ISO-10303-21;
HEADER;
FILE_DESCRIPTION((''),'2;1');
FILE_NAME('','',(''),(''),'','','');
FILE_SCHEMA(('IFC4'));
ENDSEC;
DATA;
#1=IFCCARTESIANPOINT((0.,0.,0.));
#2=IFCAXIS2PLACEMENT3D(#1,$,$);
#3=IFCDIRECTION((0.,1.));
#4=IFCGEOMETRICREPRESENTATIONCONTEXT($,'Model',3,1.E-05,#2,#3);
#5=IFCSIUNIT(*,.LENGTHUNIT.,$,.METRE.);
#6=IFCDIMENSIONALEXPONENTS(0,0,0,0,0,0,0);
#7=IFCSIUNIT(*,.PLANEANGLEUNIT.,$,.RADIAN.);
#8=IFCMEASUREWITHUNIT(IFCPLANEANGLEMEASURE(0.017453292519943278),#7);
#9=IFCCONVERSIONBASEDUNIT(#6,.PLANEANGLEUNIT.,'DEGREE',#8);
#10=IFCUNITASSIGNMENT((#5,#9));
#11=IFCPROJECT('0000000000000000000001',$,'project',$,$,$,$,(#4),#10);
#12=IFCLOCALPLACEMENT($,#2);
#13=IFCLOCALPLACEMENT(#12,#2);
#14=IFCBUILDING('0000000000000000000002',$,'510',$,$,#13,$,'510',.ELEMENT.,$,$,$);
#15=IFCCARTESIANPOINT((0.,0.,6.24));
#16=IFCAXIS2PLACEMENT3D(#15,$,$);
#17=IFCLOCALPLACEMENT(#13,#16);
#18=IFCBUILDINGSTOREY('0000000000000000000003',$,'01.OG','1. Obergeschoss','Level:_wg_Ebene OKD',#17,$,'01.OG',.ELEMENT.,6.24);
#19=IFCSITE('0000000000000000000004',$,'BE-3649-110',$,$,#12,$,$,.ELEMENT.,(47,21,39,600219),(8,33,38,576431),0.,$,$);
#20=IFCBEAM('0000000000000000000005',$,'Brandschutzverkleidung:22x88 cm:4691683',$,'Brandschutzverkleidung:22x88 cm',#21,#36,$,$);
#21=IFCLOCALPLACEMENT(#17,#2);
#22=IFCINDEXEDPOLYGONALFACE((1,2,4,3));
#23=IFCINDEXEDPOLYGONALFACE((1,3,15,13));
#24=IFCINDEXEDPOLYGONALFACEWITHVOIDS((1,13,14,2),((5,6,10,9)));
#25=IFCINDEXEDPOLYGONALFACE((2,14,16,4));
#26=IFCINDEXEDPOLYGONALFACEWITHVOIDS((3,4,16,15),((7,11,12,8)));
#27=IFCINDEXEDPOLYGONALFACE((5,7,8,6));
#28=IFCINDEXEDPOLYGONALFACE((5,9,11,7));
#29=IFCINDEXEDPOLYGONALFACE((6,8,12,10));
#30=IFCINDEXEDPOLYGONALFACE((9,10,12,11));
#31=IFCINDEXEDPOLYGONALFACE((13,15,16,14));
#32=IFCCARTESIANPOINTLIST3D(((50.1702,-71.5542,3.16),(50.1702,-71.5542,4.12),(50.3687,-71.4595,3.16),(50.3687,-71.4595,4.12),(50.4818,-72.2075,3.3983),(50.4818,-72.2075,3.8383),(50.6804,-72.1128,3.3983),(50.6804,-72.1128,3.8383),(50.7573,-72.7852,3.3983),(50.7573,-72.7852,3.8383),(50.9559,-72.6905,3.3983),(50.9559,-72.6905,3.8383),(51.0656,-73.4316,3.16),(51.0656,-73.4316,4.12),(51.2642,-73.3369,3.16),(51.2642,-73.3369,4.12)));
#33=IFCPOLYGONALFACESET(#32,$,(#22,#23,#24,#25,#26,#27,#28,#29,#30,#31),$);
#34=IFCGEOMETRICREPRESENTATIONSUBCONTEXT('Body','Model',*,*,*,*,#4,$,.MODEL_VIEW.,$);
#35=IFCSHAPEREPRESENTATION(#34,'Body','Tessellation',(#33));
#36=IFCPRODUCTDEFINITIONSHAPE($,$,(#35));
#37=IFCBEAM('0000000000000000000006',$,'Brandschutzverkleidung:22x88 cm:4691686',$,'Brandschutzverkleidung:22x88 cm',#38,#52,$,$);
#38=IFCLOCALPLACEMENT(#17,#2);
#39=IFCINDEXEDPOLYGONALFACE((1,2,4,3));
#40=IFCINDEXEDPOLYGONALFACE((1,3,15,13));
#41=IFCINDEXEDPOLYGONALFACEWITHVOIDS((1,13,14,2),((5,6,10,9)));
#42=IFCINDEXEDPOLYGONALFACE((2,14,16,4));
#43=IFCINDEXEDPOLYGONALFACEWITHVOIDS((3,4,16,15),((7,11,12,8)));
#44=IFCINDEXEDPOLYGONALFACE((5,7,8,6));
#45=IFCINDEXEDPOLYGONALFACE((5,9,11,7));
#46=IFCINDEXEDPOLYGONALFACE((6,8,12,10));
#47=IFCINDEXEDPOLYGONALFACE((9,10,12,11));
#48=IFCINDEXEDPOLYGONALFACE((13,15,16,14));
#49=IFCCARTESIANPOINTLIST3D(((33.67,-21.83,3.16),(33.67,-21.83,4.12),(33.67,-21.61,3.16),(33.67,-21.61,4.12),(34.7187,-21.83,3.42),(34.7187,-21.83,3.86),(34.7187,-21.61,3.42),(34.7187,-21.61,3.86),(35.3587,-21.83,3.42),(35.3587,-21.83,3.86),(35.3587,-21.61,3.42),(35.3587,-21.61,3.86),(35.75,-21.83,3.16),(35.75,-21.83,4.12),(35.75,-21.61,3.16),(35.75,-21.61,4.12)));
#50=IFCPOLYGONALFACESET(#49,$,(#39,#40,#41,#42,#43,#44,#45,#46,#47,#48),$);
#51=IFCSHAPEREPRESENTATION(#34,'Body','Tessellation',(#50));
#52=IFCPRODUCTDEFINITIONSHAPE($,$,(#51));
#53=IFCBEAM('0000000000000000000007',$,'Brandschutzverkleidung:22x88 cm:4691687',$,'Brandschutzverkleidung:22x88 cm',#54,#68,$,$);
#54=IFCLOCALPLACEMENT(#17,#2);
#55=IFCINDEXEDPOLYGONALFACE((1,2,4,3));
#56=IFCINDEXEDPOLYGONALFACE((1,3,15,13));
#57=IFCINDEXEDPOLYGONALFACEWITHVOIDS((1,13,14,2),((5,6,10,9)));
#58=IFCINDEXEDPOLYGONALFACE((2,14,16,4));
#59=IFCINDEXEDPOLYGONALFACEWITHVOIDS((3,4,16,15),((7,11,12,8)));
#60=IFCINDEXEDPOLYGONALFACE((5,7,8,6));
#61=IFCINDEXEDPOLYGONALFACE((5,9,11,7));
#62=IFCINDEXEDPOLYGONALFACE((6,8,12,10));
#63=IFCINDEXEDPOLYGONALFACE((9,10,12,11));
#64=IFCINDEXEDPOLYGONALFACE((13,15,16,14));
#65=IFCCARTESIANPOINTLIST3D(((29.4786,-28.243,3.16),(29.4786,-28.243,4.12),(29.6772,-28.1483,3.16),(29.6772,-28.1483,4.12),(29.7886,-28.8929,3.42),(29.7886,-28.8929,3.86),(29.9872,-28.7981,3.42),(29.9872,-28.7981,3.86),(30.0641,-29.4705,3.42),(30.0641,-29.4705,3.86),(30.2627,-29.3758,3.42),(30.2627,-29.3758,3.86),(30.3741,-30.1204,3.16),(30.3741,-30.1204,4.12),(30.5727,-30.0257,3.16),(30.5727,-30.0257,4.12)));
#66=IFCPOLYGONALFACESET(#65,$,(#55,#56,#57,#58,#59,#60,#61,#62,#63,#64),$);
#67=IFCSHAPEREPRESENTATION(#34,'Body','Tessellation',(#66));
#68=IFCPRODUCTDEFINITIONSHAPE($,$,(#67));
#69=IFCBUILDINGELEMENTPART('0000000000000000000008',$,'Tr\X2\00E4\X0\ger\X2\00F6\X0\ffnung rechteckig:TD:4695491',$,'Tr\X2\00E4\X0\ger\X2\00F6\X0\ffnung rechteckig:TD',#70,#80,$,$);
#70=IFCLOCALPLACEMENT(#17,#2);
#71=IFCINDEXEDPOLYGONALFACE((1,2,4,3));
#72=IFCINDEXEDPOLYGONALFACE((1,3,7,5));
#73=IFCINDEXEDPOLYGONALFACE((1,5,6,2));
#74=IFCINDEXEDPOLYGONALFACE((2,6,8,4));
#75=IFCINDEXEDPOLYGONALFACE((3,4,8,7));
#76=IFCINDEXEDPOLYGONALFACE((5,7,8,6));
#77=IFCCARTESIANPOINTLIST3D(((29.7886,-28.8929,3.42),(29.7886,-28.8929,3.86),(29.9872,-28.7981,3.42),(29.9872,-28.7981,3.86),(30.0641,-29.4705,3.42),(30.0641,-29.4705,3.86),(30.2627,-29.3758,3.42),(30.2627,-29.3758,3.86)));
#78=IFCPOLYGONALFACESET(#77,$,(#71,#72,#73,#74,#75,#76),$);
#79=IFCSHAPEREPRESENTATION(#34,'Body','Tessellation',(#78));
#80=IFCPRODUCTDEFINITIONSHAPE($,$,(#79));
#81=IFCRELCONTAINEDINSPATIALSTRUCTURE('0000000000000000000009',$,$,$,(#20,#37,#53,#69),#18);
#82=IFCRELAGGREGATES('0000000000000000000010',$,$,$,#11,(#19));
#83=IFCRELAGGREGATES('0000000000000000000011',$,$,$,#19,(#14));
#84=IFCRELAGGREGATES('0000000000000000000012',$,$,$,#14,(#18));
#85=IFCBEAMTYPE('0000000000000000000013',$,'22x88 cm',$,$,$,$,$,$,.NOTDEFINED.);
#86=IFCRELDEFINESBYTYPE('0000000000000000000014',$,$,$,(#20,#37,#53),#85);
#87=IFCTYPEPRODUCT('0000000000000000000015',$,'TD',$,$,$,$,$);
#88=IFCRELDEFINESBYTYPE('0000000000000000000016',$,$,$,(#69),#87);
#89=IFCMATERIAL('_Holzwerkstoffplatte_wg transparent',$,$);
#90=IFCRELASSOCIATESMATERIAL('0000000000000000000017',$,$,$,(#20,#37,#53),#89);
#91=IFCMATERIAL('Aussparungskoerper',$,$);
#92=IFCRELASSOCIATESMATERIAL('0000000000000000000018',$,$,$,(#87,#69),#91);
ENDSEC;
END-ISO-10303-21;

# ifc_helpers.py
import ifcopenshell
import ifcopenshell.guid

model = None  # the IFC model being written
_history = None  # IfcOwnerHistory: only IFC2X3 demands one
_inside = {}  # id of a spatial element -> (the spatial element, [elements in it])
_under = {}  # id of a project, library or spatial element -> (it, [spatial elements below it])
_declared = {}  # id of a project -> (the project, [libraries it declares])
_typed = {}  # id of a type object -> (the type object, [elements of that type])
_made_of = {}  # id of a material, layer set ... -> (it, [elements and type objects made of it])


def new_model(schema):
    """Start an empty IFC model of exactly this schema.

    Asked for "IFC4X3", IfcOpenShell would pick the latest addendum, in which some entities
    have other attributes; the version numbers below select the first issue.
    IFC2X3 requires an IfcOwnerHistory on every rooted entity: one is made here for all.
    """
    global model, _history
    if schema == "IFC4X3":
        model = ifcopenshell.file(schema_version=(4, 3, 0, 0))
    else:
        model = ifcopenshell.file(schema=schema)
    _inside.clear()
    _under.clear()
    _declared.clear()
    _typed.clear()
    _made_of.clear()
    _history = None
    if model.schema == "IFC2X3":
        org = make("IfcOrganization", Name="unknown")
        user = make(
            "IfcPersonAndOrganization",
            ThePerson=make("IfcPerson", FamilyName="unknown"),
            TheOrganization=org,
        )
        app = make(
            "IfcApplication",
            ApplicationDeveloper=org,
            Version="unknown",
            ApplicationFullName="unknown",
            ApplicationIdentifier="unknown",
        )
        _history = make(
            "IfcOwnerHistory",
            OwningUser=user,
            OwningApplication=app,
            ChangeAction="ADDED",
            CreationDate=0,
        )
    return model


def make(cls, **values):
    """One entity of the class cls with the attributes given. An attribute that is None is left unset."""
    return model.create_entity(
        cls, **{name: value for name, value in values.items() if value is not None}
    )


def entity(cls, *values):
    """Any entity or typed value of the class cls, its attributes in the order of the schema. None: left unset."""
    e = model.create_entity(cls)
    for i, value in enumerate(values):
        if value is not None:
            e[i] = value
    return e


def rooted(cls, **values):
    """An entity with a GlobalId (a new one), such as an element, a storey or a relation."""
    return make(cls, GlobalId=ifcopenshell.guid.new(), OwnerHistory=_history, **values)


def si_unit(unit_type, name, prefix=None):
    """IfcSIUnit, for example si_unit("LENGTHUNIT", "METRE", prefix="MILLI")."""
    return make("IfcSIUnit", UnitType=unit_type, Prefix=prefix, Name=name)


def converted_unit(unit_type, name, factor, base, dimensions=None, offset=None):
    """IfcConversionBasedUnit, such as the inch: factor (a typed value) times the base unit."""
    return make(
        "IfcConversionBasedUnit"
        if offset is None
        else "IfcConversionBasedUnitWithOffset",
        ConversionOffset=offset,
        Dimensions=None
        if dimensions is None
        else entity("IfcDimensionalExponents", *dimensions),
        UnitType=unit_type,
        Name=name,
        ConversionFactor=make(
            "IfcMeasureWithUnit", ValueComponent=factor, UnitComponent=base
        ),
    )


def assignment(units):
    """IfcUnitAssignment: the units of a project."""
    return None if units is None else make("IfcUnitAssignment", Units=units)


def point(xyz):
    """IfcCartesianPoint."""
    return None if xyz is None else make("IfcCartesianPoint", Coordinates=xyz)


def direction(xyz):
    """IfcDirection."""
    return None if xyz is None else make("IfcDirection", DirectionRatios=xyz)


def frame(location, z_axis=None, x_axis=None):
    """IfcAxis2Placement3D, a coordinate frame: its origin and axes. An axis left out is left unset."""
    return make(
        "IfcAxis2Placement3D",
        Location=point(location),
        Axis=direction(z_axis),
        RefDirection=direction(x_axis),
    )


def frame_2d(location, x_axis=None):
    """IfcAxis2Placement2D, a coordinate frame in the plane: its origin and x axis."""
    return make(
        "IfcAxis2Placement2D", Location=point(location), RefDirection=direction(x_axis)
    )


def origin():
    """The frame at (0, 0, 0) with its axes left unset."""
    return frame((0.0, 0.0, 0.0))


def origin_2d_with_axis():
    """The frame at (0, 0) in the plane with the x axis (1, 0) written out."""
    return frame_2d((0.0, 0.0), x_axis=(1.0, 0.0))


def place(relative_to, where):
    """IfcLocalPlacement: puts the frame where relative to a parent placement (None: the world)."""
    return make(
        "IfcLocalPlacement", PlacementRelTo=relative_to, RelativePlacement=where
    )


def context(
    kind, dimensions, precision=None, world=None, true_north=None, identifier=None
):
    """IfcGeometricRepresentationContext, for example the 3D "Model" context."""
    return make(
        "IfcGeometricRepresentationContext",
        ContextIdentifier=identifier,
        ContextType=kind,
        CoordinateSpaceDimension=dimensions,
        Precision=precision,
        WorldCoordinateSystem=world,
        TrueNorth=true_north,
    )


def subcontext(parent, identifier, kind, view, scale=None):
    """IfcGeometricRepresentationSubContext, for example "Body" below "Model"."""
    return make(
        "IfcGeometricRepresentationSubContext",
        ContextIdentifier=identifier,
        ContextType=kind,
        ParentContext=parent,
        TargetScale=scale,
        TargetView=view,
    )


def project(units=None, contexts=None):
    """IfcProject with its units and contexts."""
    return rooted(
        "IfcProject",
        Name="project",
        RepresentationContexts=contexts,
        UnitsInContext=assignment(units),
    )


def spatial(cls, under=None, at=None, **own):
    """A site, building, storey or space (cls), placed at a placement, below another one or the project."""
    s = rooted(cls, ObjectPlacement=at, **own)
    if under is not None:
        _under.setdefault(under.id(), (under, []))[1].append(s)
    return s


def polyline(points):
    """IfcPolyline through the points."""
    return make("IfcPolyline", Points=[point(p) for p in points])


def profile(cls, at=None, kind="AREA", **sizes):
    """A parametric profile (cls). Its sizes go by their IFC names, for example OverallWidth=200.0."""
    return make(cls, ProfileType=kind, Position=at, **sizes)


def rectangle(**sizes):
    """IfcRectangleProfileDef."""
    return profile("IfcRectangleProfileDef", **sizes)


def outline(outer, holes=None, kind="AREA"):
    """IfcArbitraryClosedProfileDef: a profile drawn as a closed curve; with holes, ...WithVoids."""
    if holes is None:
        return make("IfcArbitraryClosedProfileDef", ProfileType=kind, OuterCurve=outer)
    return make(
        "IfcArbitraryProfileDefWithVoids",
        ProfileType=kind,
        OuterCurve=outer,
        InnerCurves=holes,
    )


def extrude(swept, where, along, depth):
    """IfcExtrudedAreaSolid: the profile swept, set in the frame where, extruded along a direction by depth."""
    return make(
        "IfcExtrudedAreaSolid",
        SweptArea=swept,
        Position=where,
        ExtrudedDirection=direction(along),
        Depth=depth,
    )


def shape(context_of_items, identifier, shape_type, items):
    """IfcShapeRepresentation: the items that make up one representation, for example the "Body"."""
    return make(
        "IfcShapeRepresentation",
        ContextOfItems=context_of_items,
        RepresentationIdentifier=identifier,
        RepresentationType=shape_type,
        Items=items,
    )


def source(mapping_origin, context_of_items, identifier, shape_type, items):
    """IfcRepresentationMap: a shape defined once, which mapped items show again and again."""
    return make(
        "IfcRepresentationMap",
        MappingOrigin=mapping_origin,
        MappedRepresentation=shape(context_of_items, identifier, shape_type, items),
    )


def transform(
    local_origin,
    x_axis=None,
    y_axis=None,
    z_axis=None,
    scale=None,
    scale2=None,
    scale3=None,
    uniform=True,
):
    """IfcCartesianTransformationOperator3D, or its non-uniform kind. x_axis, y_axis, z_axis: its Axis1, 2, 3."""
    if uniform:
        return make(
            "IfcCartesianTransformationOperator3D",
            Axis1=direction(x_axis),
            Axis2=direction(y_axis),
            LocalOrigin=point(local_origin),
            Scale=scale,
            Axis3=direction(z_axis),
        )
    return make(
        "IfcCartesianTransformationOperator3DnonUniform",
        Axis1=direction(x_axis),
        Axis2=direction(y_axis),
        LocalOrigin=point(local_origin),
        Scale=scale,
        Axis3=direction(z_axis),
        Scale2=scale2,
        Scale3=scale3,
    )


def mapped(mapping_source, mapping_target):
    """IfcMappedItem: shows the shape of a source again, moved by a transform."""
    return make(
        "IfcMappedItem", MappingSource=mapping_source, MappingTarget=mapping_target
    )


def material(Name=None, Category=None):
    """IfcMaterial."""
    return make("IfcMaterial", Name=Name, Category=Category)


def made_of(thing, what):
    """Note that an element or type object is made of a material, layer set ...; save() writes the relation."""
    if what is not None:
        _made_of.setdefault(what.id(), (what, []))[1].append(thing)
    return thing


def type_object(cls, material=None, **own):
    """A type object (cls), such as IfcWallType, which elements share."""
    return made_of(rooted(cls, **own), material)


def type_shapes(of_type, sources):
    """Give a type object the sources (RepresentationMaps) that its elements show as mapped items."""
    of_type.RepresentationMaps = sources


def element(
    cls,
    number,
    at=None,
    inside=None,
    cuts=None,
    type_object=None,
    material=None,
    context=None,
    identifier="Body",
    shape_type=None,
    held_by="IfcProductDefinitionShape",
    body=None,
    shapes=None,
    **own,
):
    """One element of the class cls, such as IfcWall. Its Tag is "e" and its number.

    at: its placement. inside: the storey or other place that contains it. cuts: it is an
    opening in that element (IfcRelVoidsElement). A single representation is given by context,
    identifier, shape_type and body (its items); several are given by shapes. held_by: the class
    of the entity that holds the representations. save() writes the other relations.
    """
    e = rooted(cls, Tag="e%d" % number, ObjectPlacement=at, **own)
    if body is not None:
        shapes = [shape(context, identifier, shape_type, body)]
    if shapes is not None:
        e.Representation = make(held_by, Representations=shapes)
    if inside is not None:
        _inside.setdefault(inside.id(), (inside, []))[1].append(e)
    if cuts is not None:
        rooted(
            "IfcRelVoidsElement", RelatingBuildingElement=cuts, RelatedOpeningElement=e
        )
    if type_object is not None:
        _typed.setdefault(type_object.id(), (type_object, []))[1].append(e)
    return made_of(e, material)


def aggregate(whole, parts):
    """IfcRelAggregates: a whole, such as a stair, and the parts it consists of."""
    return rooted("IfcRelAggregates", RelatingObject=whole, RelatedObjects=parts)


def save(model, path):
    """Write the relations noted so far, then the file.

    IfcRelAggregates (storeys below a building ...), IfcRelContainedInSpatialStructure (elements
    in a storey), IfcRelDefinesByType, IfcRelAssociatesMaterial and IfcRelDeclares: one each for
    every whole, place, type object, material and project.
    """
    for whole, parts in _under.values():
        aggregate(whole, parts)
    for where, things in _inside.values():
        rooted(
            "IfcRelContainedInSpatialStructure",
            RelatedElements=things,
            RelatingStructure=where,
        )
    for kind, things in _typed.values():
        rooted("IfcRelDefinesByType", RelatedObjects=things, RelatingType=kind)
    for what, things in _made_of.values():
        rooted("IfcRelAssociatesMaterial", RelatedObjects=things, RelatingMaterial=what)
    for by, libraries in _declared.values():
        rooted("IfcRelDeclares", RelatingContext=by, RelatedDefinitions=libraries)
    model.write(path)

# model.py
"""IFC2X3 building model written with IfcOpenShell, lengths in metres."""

from ifc_helpers import new_model, entity, si_unit, converted_unit, direction, frame, origin, origin_2d_with_axis, place, context, subcontext, project, spatial, polyline, rectangle, outline, extrude, source, transform, mapped, material, type_object, type_shapes, element, save


model = new_model("IFC2X3")

# Units and contexts
model_context = context("Model", 3, precision=1e-05, world=origin(), true_north=direction((0.0, 1.0)))
body_context = subcontext(model_context, "Body", "Model", "MODEL_VIEW")
ifc_project = project(units=[si_unit("LENGTHUNIT", "METRE"), converted_unit("PLANEANGLEUNIT", "DEGREE", entity("IfcPlaneAngleMeasure", 0.017453292519943278), si_unit("PLANEANGLEUNIT", "RADIAN"), dimensions=[0, 0, 0, 0, 0, 0, 0])], contexts=[model_context])

# Site, building, storey
site_placement = place(None, origin())
site = spatial("IfcSite", under=ifc_project, at=site_placement, Name="BE-3649-110", CompositionType="ELEMENT", RefLatitude=(47, 21, 39, 600219), RefLongitude=(8, 33, 38, 576431), RefElevation=0.0)
building_placement = place(site_placement, origin())
building = spatial("IfcBuilding", under=site, at=building_placement, Name="510", LongName="510", CompositionType="ELEMENT")
storey_placement = place(building_placement, frame((0.0, 0.0, 6.24)))
storey = spatial("IfcBuildingStorey", under=building, at=storey_placement, Name="01.OG", Description="1. Obergeschoss", ObjectType="Level:_wg_Ebene OKD", LongName="01.OG", CompositionType="ELEMENT", Elevation=6.24)

# Beams
ifc_material_1 = material(Name="_Holzwerkstoffplatte_wg transparent")
beam_type_1 = type_object("IfcBeamType", Name="22x88 cm", PredefinedType="NOTDEFINED")
beam_1_placement = place(storey_placement, frame((0.0, 0.0, 3.64)))
element("IfcBeam", 1, at=beam_1_placement, inside=storey, type_object=beam_type_1, material=ifc_material_1, Name="Brandschutzverkleidung:22x88 cm:4691683", ObjectType="Brandschutzverkleidung:22x88 cm", context=body_context, shape_type="SweptSolid", body=[
    extrude(outline(polyline([(-1.04, -0.48), (1.04, -0.48), (1.04, 0.48), (-1.04, 0.48), (-1.04, -0.48)]), holes=[polyline([(0.3238, 0.2417), (0.3238, -0.1983), (-0.3162, -0.1983), (-0.3162, 0.2417), (0.3238, 0.2417)])]), frame((50.6179, -72.4929, 0.0), z_axis=(0.902585, 0.430511, 0.0), x_axis=(0.430511, -0.902585, 0.0)), (0.0, 0.0, 1.0), 0.22),
])
beam_2_placement = place(storey_placement, frame((0.0, 0.0, 3.64)))
element("IfcBeam", 2, at=beam_2_placement, inside=storey, type_object=beam_type_1, material=ifc_material_1, Name="Brandschutzverkleidung:22x88 cm:4691686", ObjectType="Brandschutzverkleidung:22x88 cm", context=body_context, shape_type="SweptSolid", body=[
    extrude(outline(polyline([(-1.04, -0.48), (1.04, -0.48), (1.04, 0.48), (-1.04, 0.48), (-1.04, -0.48)]), holes=[polyline([(0.6487, 0.22), (0.6487, -0.22), (0.0087, -0.22), (0.0087, 0.22), (0.6487, 0.22)])]), frame((34.71, -21.83, 0.0), z_axis=(0.0, 1.0, 0.0), x_axis=(1.0, 0.0, 0.0)), (0.0, 0.0, 1.0), 0.22),
])
beam_3_placement = place(storey_placement, frame((0.0, 0.0, 3.64)))
element("IfcBeam", 3, at=beam_3_placement, inside=storey, type_object=beam_type_1, material=ifc_material_1, Name="Brandschutzverkleidung:22x88 cm:4691687", ObjectType="Brandschutzverkleidung:22x88 cm", context=body_context, shape_type="SweptSolid", body=[
    extrude(outline(polyline([(-1.04, -0.48), (1.04, -0.48), (1.04, 0.48), (-1.04, 0.48), (-1.04, -0.48)]), holes=[polyline([(-0.32, -0.22), (-0.32, 0.22), (0.32, 0.22), (0.32, -0.22), (-0.32, -0.22)])]), frame((29.9264, -29.1817, 0.0), z_axis=(0.902585, 0.430511, 0.0), x_axis=(-0.430511, 0.902585, 0.0)), (0.0, 0.0, 1.0), 0.22),
])

# Building element part
ifc_material_2 = material(Name="Aussparungskoerper")
type_product = type_object("IfcTypeProduct", Name="TD", material=ifc_material_2)
shared_shape_1 = source(origin(), body_context, "Body", "SweptSolid", [
    extrude(rectangle(XDim=0.22, YDim=0.64, at=origin_2d_with_axis()), frame((30.0256, -29.1343, -0.44), z_axis=(0.0, 0.0, 1.0), x_axis=(-0.902585, -0.430511, 0.0)), (0.0, 0.0, 1.0), 0.44),
])
type_shapes(type_product, [shared_shape_1])
building_element_part_placement = place(storey_placement, frame((0.0, 0.0, 3.86)))
element("IfcBuildingElementPart", 4, at=building_element_part_placement, inside=storey, type_object=type_product, material=ifc_material_2, Name="Trägeröffnung rechteckig:TD:4695491", ObjectType="Trägeröffnung rechteckig:TD", context=body_context, shape_type="MappedRepresentation", body=[
    mapped(shared_shape_1, transform((0.0, 0.0, 0.0), scale=1.0)),
])

save(model, "model.ifc")
